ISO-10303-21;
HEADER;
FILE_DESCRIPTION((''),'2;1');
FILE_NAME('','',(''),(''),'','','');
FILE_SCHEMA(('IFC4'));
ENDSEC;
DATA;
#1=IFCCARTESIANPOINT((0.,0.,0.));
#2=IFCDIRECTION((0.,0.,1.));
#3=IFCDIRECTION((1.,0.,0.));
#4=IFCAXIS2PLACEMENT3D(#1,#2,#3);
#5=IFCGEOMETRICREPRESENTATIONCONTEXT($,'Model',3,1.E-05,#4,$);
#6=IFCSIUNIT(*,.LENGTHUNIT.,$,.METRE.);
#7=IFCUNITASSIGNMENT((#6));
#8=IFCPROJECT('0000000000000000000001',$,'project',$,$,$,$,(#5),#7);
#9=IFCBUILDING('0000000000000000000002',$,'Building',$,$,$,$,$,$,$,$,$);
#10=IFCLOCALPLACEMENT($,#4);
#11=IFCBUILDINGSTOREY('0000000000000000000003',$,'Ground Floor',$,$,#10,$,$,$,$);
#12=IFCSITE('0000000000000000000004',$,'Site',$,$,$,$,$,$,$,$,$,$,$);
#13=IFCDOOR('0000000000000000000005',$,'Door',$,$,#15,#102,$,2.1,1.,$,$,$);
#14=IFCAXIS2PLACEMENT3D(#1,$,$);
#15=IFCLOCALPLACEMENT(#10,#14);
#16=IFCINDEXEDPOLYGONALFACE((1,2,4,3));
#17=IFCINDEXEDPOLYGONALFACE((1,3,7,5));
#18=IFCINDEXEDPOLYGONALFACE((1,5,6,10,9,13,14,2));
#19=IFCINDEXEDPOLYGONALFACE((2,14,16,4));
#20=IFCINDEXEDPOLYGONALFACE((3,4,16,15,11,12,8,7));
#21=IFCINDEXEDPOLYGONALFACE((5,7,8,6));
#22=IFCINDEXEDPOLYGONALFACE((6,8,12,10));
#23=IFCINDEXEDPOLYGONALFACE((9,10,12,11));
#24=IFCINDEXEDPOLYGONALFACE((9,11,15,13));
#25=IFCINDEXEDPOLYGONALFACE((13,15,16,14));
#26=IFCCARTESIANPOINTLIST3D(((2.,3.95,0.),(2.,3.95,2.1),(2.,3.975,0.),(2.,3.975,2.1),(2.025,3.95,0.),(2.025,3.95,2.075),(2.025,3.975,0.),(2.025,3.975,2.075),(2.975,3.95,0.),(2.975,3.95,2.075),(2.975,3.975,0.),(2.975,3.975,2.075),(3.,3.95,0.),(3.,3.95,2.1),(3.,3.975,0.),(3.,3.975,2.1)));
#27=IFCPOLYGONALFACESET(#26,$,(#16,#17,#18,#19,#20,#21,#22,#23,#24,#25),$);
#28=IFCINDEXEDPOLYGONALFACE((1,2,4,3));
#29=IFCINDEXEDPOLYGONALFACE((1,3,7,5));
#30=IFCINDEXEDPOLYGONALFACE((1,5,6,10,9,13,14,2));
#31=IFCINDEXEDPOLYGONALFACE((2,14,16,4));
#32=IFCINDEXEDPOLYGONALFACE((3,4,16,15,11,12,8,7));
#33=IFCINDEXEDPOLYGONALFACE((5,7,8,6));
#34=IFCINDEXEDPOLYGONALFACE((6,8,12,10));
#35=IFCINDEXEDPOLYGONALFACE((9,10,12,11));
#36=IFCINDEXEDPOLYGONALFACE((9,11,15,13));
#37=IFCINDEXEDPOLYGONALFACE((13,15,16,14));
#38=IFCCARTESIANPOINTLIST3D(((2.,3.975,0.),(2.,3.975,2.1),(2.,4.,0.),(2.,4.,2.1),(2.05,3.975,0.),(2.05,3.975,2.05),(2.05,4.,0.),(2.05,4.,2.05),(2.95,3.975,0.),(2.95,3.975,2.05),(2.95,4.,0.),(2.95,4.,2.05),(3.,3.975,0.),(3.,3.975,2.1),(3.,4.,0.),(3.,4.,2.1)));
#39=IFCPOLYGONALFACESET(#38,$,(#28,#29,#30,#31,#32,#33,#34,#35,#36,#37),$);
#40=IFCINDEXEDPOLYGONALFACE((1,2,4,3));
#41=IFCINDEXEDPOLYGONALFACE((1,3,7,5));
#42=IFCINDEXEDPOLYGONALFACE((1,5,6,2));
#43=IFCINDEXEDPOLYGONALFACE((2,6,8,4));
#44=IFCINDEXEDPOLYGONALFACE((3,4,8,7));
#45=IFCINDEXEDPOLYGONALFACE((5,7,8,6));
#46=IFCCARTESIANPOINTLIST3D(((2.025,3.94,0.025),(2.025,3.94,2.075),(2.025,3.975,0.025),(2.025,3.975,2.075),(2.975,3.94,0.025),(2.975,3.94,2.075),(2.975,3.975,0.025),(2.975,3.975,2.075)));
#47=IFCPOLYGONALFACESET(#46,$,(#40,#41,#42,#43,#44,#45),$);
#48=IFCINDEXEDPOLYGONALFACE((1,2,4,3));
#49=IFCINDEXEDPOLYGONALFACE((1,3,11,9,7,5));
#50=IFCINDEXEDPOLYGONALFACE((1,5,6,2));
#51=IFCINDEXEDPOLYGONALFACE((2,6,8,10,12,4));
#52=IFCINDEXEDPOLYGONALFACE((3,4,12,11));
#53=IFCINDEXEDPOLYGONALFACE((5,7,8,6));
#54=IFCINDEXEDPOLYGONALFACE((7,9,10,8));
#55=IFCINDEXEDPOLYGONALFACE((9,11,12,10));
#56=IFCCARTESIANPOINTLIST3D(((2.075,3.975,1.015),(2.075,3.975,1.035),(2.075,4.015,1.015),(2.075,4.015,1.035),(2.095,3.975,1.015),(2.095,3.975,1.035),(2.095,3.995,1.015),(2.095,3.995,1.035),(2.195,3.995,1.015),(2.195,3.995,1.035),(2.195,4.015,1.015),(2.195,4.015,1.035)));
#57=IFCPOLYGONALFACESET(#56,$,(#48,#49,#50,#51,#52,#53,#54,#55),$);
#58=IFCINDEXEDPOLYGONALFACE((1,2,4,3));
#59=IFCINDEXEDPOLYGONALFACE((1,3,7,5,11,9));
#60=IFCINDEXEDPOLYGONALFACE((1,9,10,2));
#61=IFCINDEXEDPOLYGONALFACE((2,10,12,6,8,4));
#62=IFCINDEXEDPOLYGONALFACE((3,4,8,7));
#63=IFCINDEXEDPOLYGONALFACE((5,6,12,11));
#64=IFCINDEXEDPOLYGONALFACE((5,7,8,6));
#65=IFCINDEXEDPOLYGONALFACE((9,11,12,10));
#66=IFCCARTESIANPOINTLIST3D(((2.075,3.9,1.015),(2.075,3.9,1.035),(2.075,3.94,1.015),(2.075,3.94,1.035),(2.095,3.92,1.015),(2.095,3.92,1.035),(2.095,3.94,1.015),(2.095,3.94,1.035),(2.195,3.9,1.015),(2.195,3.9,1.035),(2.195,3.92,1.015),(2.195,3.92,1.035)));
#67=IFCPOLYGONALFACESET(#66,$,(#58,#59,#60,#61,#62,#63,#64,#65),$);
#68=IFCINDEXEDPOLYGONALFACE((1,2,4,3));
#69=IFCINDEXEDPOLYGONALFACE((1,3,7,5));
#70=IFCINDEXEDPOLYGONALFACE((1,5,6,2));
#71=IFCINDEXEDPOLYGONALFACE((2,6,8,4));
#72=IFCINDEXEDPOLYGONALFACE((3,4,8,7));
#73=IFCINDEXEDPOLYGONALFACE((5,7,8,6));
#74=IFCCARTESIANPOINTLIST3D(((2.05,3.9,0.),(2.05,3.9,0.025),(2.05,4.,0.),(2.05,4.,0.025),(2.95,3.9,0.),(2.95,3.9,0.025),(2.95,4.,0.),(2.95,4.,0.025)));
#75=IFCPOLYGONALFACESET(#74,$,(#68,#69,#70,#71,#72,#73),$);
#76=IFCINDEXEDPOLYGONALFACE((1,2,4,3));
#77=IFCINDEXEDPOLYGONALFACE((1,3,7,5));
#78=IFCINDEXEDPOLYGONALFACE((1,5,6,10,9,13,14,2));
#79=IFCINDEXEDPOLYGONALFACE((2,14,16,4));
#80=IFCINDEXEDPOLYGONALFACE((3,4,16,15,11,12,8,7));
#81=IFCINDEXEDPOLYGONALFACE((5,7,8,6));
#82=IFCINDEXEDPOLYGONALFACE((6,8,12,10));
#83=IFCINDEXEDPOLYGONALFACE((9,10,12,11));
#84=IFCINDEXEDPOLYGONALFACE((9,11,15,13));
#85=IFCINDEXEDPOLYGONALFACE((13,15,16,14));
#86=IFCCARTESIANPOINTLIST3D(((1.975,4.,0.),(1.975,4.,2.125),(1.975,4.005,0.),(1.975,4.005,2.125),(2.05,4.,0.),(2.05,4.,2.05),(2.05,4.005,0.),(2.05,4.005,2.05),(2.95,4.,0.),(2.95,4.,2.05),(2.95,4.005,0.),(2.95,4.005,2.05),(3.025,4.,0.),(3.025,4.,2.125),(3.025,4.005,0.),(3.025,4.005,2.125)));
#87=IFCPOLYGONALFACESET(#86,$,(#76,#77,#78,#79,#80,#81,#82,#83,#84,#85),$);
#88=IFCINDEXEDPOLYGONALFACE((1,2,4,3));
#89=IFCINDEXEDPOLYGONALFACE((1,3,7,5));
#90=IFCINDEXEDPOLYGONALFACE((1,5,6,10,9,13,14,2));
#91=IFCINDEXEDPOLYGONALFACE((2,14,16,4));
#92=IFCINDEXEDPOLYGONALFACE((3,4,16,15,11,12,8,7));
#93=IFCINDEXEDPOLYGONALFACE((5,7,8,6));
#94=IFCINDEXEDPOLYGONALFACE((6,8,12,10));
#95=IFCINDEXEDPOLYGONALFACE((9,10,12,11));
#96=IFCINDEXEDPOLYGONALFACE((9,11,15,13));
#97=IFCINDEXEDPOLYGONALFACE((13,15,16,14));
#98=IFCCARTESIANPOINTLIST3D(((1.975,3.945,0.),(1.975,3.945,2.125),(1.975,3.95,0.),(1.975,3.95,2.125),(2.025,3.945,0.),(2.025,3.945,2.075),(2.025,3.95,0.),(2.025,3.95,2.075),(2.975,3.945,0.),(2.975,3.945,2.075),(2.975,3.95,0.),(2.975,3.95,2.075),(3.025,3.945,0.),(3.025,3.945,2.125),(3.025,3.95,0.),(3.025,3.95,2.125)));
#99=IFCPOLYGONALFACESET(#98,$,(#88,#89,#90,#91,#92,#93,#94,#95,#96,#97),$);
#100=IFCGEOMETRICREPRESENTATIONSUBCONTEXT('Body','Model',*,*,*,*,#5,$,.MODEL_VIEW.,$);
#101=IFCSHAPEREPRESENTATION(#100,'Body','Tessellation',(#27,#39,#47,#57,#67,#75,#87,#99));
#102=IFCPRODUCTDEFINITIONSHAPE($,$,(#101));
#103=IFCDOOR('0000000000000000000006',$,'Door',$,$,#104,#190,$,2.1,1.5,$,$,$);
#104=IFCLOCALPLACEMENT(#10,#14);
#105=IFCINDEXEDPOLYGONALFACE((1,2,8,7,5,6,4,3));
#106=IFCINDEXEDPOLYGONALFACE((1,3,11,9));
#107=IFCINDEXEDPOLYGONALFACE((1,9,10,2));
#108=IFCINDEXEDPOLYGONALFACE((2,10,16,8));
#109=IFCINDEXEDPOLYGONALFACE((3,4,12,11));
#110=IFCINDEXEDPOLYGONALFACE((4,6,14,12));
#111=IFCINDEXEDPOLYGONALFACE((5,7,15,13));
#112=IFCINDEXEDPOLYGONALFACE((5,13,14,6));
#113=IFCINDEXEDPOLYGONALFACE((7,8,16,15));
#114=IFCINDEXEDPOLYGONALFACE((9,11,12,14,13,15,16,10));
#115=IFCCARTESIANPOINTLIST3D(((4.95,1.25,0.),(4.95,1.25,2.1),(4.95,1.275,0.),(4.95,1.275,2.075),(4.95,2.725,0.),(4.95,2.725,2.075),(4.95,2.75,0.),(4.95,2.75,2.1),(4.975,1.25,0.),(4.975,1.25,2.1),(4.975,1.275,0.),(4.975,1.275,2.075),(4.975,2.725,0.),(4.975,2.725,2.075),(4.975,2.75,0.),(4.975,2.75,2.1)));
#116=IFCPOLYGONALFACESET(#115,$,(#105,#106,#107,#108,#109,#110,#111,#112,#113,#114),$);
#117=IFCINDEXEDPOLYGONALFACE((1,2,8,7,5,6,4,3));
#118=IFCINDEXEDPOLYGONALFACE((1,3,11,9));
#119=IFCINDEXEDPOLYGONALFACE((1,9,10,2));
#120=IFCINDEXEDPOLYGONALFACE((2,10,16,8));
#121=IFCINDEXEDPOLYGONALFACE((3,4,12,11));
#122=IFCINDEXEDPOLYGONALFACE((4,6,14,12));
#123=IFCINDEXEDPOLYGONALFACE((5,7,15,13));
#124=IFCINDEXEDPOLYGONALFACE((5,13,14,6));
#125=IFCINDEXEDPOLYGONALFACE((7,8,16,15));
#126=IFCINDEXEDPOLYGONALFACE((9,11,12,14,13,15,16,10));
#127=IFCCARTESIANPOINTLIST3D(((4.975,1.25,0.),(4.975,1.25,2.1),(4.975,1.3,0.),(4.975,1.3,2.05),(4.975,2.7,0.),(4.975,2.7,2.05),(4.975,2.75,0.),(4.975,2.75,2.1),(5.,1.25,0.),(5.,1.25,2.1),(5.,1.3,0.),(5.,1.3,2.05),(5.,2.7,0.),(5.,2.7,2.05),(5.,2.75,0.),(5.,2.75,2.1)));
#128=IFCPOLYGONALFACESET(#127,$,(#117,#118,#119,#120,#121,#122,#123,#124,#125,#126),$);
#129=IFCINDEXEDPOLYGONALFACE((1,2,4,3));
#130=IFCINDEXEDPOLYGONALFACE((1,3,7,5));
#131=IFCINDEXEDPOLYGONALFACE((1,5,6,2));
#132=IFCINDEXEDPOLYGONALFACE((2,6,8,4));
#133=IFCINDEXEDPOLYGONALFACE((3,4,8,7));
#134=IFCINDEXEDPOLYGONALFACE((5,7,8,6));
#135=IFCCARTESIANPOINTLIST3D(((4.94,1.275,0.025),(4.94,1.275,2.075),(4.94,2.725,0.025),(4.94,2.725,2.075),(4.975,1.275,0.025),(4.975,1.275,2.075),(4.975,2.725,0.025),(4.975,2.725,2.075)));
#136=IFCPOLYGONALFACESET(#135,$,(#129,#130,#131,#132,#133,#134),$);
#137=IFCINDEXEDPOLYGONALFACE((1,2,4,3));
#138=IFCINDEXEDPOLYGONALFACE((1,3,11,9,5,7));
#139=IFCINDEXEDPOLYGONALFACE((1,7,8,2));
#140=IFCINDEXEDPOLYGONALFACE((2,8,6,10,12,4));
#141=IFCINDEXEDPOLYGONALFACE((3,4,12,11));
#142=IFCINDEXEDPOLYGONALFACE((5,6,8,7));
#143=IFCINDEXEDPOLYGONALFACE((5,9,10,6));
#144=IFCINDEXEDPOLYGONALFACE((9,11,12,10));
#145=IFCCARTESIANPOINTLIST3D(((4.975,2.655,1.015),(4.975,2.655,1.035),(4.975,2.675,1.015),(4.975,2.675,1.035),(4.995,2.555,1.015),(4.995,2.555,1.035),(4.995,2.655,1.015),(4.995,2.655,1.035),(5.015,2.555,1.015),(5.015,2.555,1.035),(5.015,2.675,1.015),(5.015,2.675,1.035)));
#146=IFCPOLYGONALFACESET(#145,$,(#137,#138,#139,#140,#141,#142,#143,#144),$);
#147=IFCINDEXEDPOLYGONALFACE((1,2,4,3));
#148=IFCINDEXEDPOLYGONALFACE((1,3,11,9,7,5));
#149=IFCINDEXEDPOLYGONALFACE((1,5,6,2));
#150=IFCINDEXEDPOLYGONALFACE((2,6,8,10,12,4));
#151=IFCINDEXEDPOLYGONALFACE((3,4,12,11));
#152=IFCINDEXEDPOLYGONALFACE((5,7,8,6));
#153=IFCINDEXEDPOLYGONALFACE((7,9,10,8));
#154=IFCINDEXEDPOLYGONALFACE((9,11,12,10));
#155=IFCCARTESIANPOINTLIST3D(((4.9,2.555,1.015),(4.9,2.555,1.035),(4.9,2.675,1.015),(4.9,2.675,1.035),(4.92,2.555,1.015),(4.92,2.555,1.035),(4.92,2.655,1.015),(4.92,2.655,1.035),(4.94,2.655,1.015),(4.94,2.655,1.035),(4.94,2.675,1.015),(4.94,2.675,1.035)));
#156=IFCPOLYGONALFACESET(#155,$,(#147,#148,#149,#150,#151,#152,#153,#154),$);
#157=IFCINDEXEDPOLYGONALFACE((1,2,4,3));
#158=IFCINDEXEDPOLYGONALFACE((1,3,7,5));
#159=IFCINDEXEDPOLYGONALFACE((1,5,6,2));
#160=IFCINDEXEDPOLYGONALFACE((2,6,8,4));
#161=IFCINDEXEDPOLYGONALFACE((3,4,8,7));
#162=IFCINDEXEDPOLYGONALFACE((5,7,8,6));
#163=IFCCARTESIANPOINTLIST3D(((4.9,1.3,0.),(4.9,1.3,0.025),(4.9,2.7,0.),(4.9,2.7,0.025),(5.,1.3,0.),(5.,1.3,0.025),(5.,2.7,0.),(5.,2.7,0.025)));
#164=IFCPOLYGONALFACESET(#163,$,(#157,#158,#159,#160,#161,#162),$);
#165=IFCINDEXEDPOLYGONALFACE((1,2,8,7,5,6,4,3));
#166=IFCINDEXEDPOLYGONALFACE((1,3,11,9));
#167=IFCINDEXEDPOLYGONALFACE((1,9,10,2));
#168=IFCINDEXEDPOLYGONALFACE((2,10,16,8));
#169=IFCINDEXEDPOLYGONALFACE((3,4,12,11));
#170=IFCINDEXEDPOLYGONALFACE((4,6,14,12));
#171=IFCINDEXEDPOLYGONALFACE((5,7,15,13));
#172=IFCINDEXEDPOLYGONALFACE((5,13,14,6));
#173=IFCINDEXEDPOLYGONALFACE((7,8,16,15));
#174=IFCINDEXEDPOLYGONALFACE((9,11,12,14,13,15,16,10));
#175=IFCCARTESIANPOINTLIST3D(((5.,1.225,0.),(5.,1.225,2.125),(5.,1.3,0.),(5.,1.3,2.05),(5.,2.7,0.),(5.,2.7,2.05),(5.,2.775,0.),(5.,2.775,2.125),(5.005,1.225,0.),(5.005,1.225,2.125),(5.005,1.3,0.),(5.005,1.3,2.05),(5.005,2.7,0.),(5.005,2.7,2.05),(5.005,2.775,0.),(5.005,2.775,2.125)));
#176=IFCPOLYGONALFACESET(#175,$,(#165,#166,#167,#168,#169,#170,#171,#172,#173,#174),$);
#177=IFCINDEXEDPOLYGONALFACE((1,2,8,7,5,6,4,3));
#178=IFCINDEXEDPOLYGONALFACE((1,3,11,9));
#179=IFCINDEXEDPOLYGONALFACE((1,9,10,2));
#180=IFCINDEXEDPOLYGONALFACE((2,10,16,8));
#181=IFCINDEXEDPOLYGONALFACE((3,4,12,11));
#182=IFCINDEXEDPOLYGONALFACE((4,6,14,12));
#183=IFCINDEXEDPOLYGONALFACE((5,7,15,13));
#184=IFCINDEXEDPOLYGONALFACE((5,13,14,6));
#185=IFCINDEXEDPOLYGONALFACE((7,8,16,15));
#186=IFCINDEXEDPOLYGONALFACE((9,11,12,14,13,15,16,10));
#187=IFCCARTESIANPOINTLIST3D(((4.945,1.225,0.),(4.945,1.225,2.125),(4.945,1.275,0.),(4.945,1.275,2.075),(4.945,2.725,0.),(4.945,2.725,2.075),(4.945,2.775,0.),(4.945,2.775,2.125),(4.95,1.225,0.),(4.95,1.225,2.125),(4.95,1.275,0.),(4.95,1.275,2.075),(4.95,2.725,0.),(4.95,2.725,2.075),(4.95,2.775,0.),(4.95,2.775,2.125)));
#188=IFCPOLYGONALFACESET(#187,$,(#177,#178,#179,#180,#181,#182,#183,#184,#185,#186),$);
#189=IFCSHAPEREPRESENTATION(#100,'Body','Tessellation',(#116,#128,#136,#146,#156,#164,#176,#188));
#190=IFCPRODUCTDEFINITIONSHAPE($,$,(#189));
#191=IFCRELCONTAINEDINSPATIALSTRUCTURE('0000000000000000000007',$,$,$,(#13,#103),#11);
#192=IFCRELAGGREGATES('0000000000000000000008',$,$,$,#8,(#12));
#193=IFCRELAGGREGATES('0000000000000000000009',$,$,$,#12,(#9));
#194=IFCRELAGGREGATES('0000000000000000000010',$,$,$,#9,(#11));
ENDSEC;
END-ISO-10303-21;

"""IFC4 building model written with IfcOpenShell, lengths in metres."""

from ifc_helpers import new_model, si_unit, frame, origin_with_axes, place, context, subcontext, project, spatial, line, indexed_curve, outline, extrude, element, save


model = new_model("IFC4")

# Units and contexts
model_context = context("Model", 3, precision=1e-05, world=origin_with_axes())
body_context = subcontext(model_context, "Body", "Model", "MODEL_VIEW")
ifc_project = project(units=[si_unit("LENGTHUNIT", "METRE")], contexts=[model_context])

# Site, building, storey
site = spatial("IfcSite", under=ifc_project, Name="Site")
building = spatial("IfcBuilding", under=site, Name="Building")
storey_placement = place(None, origin_with_axes())
storey = spatial("IfcBuildingStorey", under=building, at=storey_placement, Name="Ground Floor")

# Doors
door_1_placement = place(storey_placement, frame((3.0, 4.0, 0.0), z_axis=(0.0, 0.0, 1.0), x_axis=(-1.0, 0.0, 0.0)))
element("IfcDoor", 1, at=door_1_placement, inside=storey, Name="Door", OverallHeight=2.1, OverallWidth=1.0, context=body_context, shape_type="SweptSolid", body=[
    extrude(outline(indexed_curve([(0.0, 0.0), (0.0, 2.1), (1.0, 2.1), (1.0, 0.0), (0.975, 0.0), (0.975, 2.075), (0.025, 2.075), (0.025, 0.0)], segments=[line(1, 2, 3, 4, 5, 6, 7, 8, 1)])), frame((0.0, 0.025, 0.0), z_axis=(0.0, -1.0, 0.0), x_axis=(1.0, 0.0, 0.0)), (0.0, 0.0, -1.0), 0.025),
    extrude(outline(indexed_curve([(0.0, 0.0), (0.0, 2.1), (1.0, 2.1), (1.0, 0.0), (0.95, 0.0), (0.95, 2.05), (0.05, 2.05), (0.05, 0.0)], segments=[line(1, 2, 3, 4, 5, 6, 7, 8, 1)])), frame((0.0, 0.0, 0.0), z_axis=(0.0, -1.0, 0.0), x_axis=(1.0, 0.0, 0.0)), (0.0, 0.0, -1.0), 0.025),
    extrude(outline(indexed_curve([(0.0, 0.0), (0.95, 0.0), (0.95, 0.035), (0.0, 0.035)], segments=[line(1, 2, 3, 4, 1)])), frame((0.025, 0.025, 0.025), z_axis=(0.0, 0.0, 1.0), x_axis=(1.0, 0.0, 0.0)), (0.0, 0.0, 1.0), 2.05),
    extrude(outline(indexed_curve([(0.0, 0.0), (0.0, -0.04), (-0.12, -0.04), (-0.12, -0.02), (-0.02, -0.02), (-0.02, 0.0)], segments=[line(1, 2, 3, 4, 5, 6, 1)])), frame((0.925, 0.025, 1.015), z_axis=(0.0, 0.0, 1.0), x_axis=(1.0, 0.0, 0.0)), (0.0, 0.0, 1.0), 0.02),
    extrude(outline(indexed_curve([(0.0, 0.0), (0.0, 0.04), (-0.12, 0.04), (-0.12, 0.02), (-0.02, 0.02), (-0.02, 0.0)], segments=[line(1, 2, 3, 4, 5, 6, 1)])), frame((0.925, 0.06, 1.015), z_axis=(0.0, 0.0, 1.0), x_axis=(1.0, 0.0, 0.0)), (0.0, 0.0, 1.0), 0.02),
    extrude(outline(indexed_curve([(0.0, 0.0), (0.9, 0.0), (0.9, 0.1), (0.0, 0.1)], segments=[line(1, 2, 3, 4, 1)])), frame((0.05, 0.0, 0.0), z_axis=(0.0, 0.0, 1.0), x_axis=(1.0, 0.0, 0.0)), (0.0, 0.0, 1.0), 0.025),
    extrude(outline(indexed_curve([(0.0, 0.0), (0.0, 2.125), (1.05, 2.125), (1.05, 0.0), (0.975, 0.0), (0.975, 2.05), (0.075, 2.05), (0.075, 0.0)], segments=[line(1, 2, 3, 4, 5, 6, 7, 8, 1)])), frame((-0.025, -0.005, 0.0), z_axis=(0.0, -1.0, 0.0), x_axis=(1.0, 0.0, 0.0)), (0.0, 0.0, -1.0), 0.005),
    extrude(outline(indexed_curve([(0.0, 0.0), (0.0, 2.125), (1.05, 2.125), (1.05, 0.0), (1.0, 0.0), (1.0, 2.075), (0.05, 2.075), (0.05, 0.0)], segments=[line(1, 2, 3, 4, 5, 6, 7, 8, 1)])), frame((-0.025, 0.05, 0.0), z_axis=(0.0, -1.0, 0.0), x_axis=(1.0, 0.0, 0.0)), (0.0, 0.0, -1.0), 0.005),
])
door_2_placement = place(storey_placement, frame((5.0, 1.25, 0.0), z_axis=(0.0, 0.0, 1.0), x_axis=(0.0, 1.0, 0.0)))
element("IfcDoor", 2, at=door_2_placement, inside=storey, Name="Door", OverallHeight=2.1, OverallWidth=1.5, context=body_context, shape_type="SweptSolid", body=[
    extrude(outline(indexed_curve([(0.0, 0.0), (0.0, 2.1), (1.5, 2.1), (1.5, 0.0), (1.475, 0.0), (1.475, 2.075), (0.025, 2.075), (0.025, 0.0)], segments=[line(1, 2, 3, 4, 5, 6, 7, 8, 1)])), frame((0.0, 0.025, 0.0), z_axis=(0.0, -1.0, 0.0), x_axis=(1.0, 0.0, 0.0)), (0.0, 0.0, -1.0), 0.025),
    extrude(outline(indexed_curve([(0.0, 0.0), (0.0, 2.1), (1.5, 2.1), (1.5, 0.0), (1.45, 0.0), (1.45, 2.05), (0.05, 2.05), (0.05, 0.0)], segments=[line(1, 2, 3, 4, 5, 6, 7, 8, 1)])), frame((0.0, 0.0, 0.0), z_axis=(0.0, -1.0, 0.0), x_axis=(1.0, 0.0, 0.0)), (0.0, 0.0, -1.0), 0.025),
    extrude(outline(indexed_curve([(0.0, 0.0), (1.45, 0.0), (1.45, 0.035), (0.0, 0.035)], segments=[line(1, 2, 3, 4, 1)])), frame((0.025, 0.025, 0.025), z_axis=(0.0, 0.0, 1.0), x_axis=(1.0, 0.0, 0.0)), (0.0, 0.0, 1.0), 2.05),
    extrude(outline(indexed_curve([(0.0, 0.0), (0.0, -0.04), (-0.12, -0.04), (-0.12, -0.02), (-0.02, -0.02), (-0.02, 0.0)], segments=[line(1, 2, 3, 4, 5, 6, 1)])), frame((1.425, 0.025, 1.015), z_axis=(0.0, 0.0, 1.0), x_axis=(1.0, 0.0, 0.0)), (0.0, 0.0, 1.0), 0.02),
    extrude(outline(indexed_curve([(0.0, 0.0), (0.0, 0.04), (-0.12, 0.04), (-0.12, 0.02), (-0.02, 0.02), (-0.02, 0.0)], segments=[line(1, 2, 3, 4, 5, 6, 1)])), frame((1.425, 0.06, 1.015), z_axis=(0.0, 0.0, 1.0), x_axis=(1.0, 0.0, 0.0)), (0.0, 0.0, 1.0), 0.02),
    extrude(outline(indexed_curve([(0.0, 0.0), (1.4, 0.0), (1.4, 0.1), (0.0, 0.1)], segments=[line(1, 2, 3, 4, 1)])), frame((0.05, 0.0, 0.0), z_axis=(0.0, 0.0, 1.0), x_axis=(1.0, 0.0, 0.0)), (0.0, 0.0, 1.0), 0.025),
    extrude(outline(indexed_curve([(0.0, 0.0), (0.0, 2.125), (1.55, 2.125), (1.55, 0.0), (1.475, 0.0), (1.475, 2.05), (0.075, 2.05), (0.075, 0.0)], segments=[line(1, 2, 3, 4, 5, 6, 7, 8, 1)])), frame((-0.025, -0.005, 0.0), z_axis=(0.0, -1.0, 0.0), x_axis=(1.0, 0.0, 0.0)), (0.0, 0.0, -1.0), 0.005),
    extrude(outline(indexed_curve([(0.0, 0.0), (0.0, 2.125), (1.55, 2.125), (1.55, 0.0), (1.5, 0.0), (1.5, 2.075), (0.05, 2.075), (0.05, 0.0)], segments=[line(1, 2, 3, 4, 5, 6, 7, 8, 1)])), frame((-0.025, 0.05, 0.0), z_axis=(0.0, -1.0, 0.0), x_axis=(1.0, 0.0, 0.0)), (0.0, 0.0, -1.0), 0.005),
])

save(model, "model.ifc")
